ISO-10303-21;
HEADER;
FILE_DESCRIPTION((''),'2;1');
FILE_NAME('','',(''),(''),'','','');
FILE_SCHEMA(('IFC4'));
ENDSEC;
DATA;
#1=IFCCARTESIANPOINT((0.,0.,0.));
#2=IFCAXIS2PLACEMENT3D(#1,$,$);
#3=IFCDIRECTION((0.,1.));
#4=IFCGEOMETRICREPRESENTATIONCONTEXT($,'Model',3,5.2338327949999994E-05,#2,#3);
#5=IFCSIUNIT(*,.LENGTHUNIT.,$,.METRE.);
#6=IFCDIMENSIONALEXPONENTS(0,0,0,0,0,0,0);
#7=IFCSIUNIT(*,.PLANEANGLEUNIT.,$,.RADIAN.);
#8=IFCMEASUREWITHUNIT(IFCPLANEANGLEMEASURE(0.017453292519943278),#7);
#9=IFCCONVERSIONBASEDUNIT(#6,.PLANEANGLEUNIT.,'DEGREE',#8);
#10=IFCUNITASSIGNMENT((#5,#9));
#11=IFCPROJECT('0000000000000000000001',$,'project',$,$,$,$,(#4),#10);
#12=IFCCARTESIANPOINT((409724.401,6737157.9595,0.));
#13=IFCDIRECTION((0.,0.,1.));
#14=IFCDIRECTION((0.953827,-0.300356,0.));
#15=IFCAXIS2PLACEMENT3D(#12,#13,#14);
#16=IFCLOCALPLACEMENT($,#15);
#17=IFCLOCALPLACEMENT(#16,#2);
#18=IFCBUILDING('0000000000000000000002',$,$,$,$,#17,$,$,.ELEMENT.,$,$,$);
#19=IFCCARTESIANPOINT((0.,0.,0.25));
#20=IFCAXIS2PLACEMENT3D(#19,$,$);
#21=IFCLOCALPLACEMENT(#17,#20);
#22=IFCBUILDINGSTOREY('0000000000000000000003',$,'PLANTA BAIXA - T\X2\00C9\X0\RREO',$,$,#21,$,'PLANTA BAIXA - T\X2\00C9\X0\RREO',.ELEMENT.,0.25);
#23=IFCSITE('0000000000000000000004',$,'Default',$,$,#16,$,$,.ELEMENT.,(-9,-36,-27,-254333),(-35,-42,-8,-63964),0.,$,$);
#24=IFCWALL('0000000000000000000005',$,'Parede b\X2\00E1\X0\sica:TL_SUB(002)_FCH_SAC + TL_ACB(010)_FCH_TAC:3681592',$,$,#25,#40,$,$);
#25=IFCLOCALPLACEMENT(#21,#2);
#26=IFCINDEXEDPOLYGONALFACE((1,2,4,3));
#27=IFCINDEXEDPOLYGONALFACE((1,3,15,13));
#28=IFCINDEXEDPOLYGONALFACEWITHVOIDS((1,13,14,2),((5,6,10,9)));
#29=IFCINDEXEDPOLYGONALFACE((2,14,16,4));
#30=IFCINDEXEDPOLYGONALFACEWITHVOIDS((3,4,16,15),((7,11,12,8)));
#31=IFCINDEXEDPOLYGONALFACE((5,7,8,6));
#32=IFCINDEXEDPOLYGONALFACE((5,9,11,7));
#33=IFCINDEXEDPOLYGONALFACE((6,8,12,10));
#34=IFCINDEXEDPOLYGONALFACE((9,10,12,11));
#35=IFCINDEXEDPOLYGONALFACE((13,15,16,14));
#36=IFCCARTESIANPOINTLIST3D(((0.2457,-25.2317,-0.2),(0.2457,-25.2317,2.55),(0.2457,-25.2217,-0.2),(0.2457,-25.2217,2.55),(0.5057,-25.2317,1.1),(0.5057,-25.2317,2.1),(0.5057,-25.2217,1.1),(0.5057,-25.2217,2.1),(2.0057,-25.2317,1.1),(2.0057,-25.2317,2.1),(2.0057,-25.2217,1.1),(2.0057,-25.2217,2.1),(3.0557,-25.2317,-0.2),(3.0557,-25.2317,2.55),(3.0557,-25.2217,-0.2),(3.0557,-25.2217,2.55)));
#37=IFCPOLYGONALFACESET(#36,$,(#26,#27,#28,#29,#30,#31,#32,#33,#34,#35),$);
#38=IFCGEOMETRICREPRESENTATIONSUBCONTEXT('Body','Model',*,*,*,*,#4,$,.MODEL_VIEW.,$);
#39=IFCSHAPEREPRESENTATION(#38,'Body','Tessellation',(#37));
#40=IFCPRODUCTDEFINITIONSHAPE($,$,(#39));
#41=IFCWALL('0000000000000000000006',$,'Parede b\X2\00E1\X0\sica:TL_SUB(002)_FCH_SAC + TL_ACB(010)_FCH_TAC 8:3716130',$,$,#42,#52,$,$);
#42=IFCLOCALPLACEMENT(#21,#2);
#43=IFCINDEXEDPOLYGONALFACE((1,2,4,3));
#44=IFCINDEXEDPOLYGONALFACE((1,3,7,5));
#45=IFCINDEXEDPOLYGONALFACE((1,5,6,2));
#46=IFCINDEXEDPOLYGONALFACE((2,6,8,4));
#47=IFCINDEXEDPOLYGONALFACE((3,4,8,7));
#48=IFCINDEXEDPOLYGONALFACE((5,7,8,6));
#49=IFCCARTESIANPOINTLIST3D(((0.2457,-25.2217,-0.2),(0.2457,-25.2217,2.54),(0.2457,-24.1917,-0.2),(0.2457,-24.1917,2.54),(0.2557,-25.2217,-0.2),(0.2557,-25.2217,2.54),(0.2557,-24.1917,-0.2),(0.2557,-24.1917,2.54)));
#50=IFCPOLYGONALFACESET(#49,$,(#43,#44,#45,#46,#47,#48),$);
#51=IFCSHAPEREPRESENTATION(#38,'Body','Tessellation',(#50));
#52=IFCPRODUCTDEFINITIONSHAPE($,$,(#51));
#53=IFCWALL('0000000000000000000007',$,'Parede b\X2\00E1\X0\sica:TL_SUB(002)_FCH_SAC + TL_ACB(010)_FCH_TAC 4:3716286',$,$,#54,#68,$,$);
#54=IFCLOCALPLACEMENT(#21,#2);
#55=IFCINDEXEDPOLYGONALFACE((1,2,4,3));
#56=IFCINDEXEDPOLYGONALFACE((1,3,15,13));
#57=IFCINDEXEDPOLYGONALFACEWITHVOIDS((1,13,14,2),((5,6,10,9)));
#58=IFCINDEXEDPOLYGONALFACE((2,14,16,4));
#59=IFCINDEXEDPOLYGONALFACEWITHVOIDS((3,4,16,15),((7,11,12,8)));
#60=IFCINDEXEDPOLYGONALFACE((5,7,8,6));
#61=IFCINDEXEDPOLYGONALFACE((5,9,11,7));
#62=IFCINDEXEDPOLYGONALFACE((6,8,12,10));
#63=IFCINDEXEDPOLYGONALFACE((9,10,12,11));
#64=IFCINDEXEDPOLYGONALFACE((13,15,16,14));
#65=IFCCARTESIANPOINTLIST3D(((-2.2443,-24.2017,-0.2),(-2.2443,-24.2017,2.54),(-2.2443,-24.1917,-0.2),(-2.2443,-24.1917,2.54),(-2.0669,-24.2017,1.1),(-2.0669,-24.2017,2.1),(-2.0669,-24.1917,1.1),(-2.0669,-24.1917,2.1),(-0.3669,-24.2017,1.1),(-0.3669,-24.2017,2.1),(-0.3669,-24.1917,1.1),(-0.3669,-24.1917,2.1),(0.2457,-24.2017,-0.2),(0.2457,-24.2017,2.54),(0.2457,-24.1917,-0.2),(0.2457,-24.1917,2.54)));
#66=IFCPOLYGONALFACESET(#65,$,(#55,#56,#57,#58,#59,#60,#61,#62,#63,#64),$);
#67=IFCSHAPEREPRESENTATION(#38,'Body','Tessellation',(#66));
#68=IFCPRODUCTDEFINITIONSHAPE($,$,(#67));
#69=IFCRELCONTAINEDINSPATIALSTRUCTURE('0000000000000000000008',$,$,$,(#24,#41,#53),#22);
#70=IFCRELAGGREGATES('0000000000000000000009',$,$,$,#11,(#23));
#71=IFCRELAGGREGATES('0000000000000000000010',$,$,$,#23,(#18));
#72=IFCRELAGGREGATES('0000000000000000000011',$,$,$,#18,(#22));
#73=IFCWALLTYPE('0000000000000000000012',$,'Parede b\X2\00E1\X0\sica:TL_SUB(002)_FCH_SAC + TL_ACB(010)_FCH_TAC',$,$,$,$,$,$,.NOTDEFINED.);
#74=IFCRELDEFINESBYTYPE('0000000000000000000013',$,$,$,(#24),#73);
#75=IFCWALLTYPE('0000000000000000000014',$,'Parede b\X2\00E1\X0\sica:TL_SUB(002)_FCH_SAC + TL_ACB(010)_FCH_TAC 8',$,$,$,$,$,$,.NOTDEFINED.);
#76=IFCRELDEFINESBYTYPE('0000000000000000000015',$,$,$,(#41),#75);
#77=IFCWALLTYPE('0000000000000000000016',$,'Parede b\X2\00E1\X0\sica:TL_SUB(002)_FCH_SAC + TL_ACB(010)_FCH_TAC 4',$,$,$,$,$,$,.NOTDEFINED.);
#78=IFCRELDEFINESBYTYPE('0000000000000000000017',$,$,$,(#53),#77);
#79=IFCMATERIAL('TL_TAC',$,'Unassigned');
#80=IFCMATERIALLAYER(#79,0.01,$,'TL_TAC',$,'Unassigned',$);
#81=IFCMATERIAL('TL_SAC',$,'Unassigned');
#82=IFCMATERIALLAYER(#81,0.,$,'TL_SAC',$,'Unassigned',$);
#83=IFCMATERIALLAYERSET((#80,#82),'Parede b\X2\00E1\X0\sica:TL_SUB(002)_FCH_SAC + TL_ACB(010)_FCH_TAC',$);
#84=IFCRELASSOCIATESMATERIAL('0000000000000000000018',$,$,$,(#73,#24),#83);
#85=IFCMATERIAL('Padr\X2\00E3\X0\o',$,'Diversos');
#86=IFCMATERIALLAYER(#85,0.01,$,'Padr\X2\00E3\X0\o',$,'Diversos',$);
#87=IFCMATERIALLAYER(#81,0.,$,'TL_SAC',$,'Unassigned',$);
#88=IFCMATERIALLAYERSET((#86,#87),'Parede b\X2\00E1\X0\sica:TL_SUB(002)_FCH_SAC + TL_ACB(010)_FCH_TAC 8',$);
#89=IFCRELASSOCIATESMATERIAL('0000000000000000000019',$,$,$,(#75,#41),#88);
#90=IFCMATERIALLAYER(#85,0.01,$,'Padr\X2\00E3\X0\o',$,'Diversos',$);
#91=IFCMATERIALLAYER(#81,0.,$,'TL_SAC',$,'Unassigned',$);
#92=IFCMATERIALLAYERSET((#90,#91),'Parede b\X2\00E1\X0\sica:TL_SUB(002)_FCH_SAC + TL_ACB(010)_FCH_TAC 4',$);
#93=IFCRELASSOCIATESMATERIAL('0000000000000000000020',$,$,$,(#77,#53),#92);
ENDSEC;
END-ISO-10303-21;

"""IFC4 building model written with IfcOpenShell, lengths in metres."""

from ifc_helpers import new_model, entity, si_unit, converted_unit, direction, frame, frame_2d, origin, place, context, subcontext, project, spatial, rectangle, extrude, material, layer, layer_set, layer_usage, type_object, element, save


model = new_model("IFC4")

# Units and contexts
model_context = context("Model", 3, precision=5.2338327949999994e-05, world=origin(), true_north=direction((0.0, 1.0)))
body_context = subcontext(model_context, "Body", "Model", "MODEL_VIEW")
ifc_project = project(units=[si_unit("LENGTHUNIT", "METRE"), converted_unit("PLANEANGLEUNIT", "DEGREE", entity("IfcPlaneAngleMeasure", 0.017453292519943278), si_unit("PLANEANGLEUNIT", "RADIAN"), dimensions=[0, 0, 0, 0, 0, 0, 0])], contexts=[model_context])

# Site, building, storey
site_placement = place(None, frame((409724.401, 6737157.9595, 0.0), z_axis=(0.0, 0.0, 1.0), x_axis=(0.953827, -0.300356, 0.0)))
site = spatial("IfcSite", under=ifc_project, at=site_placement, Name="Default", CompositionType="ELEMENT", RefLatitude=(-9, -36, -27, -254333), RefLongitude=(-35, -42, -8, -63964), RefElevation=0.0)
building_placement = place(site_placement, origin())
building = spatial("IfcBuilding", under=site, at=building_placement, CompositionType="ELEMENT")
storey_placement = place(building_placement, frame((0.0, 0.0, 0.25)))
storey = spatial("IfcBuildingStorey", under=building, at=storey_placement, Name="PLANTA BAIXA - TÉRREO", LongName="PLANTA BAIXA - TÉRREO", CompositionType="ELEMENT", Elevation=0.25)

# Shared definitions
ifc_material_1 = material(Name="TL_SAC", Category="Unassigned")

# Wall, opening
ifc_material_2 = material(Name="TL_TAC", Category="Unassigned")
ifc_layer_1 = layer(ifc_material_2, 0.01, Name="TL_TAC", Category="Unassigned")
ifc_layer_2 = layer(ifc_material_1, 0.0, Name="TL_SAC", Category="Unassigned")
ifc_layer_set_1 = layer_set([ifc_layer_1, ifc_layer_2], Name="Parede básica:TL_SUB(002)_FCH_SAC + TL_ACB(010)_FCH_TAC")
ifc_layer_usage_1 = layer_usage(ifc_layer_set_1, "AXIS2", "NEGATIVE", 0.005)
wall_type_1 = type_object("IfcWallType", Name="Parede básica:TL_SUB(002)_FCH_SAC + TL_ACB(010)_FCH_TAC", PredefinedType="NOTDEFINED", material=ifc_layer_set_1)
wall_1_placement = place(storey_placement, frame((3.0557, -25.2267, -0.2), z_axis=(0.0, 0.0, 1.0), x_axis=(-1.0, 0.0, 0.0)))
wall_1 = element("IfcWall", 1, at=wall_1_placement, inside=storey, type_object=wall_type_1, material=ifc_layer_usage_1, Name="Parede básica:TL_SUB(002)_FCH_SAC + TL_ACB(010)_FCH_TAC:3681592", context=body_context, shape_type="SweptSolid", body=[
    extrude(rectangle(XDim=2.81, YDim=0.01, at=frame_2d((1.405, 0.0), x_axis=(-1.0, 0.0))), origin(), (0.0, 0.0, 1.0), 2.75),
])
opening_1_placement = place(wall_1_placement, frame((3.0557, -25.2267, 1.3)))
element("IfcOpeningElement", 2, at=opening_1_placement, cuts=wall_1, PredefinedType="OPENING", context=body_context, shape_type="SweptSolid", body=[
    extrude(rectangle(XDim=1.0, YDim=1.5, at=frame_2d((0.0, 0.0), x_axis=(0.0, 1.0))), frame((-1.2557, 23.5977, 0.5), z_axis=(0.0, 1.0, 0.0), x_axis=(1.0, 0.0, 0.0)), (0.0, 0.0, 1.0), 3.048),
])

# Wall
ifc_material_3 = material(Name="Padrão", Category="Diversos")
ifc_layer_3 = layer(ifc_material_3, 0.01, Name="Padrão", Category="Diversos")
ifc_layer_4 = layer(ifc_material_1, 0.0, Name="TL_SAC", Category="Unassigned")
ifc_layer_set_2 = layer_set([ifc_layer_3, ifc_layer_4], Name="Parede básica:TL_SUB(002)_FCH_SAC + TL_ACB(010)_FCH_TAC 8")
ifc_layer_usage_2 = layer_usage(ifc_layer_set_2, "AXIS2", "POSITIVE", -0.005)
wall_type_2 = type_object("IfcWallType", Name="Parede básica:TL_SUB(002)_FCH_SAC + TL_ACB(010)_FCH_TAC 8", PredefinedType="NOTDEFINED", material=ifc_layer_set_2)
wall_2_placement = place(storey_placement, frame((0.2507, -25.2217, -0.2), z_axis=(0.0, 0.0, 1.0), x_axis=(0.0, 1.0, 0.0)))
element("IfcWall", 3, at=wall_2_placement, inside=storey, type_object=wall_type_2, material=ifc_layer_usage_2, Name="Parede básica:TL_SUB(002)_FCH_SAC + TL_ACB(010)_FCH_TAC 8:3716130", context=body_context, shape_type="SweptSolid", body=[
    extrude(rectangle(XDim=1.03, YDim=0.01, at=frame_2d((0.515, 0.0), x_axis=(-1.0, 0.0))), origin(), (0.0, 0.0, 1.0), 2.74),
])

# Wall, opening
ifc_layer_5 = layer(ifc_material_3, 0.01, Name="Padrão", Category="Diversos")
ifc_layer_6 = layer(ifc_material_1, 0.0, Name="TL_SAC", Category="Unassigned")
ifc_layer_set_3 = layer_set([ifc_layer_5, ifc_layer_6], Name="Parede básica:TL_SUB(002)_FCH_SAC + TL_ACB(010)_FCH_TAC 4")
ifc_layer_usage_3 = layer_usage(ifc_layer_set_3, "AXIS2", "POSITIVE", -0.005)
wall_type_3 = type_object("IfcWallType", Name="Parede básica:TL_SUB(002)_FCH_SAC + TL_ACB(010)_FCH_TAC 4", PredefinedType="NOTDEFINED", material=ifc_layer_set_3)
wall_3_placement = place(storey_placement, frame((0.2457, -24.1967, -0.2), z_axis=(0.0, 0.0, 1.0), x_axis=(-1.0, 0.0, 0.0)))
wall_3 = element("IfcWall", 4, at=wall_3_placement, inside=storey, type_object=wall_type_3, material=ifc_layer_usage_3, Name="Parede básica:TL_SUB(002)_FCH_SAC + TL_ACB(010)_FCH_TAC 4:3716286", context=body_context, shape_type="SweptSolid", body=[
    extrude(rectangle(XDim=2.49, YDim=0.01, at=frame_2d((1.245, 0.0), x_axis=(-1.0, 0.0))), origin(), (0.0, 0.0, 1.0), 2.74),
])
opening_2_placement = place(wall_3_placement, frame((0.2457, -24.1967, 1.3)))
element("IfcOpeningElement", 5, at=opening_2_placement, cuts=wall_3, PredefinedType="OPENING", context=body_context, shape_type="SweptSolid", body=[
    extrude(rectangle(XDim=1.0, YDim=1.7, at=frame_2d((0.0, 0.0), x_axis=(0.0, 1.0))), frame((1.2169, 22.5677, 0.5), z_axis=(0.0, 1.0, 0.0), x_axis=(1.0, 0.0, 0.0)), (0.0, 0.0, 1.0), 3.048),
])

save(model, "model.ifc")
